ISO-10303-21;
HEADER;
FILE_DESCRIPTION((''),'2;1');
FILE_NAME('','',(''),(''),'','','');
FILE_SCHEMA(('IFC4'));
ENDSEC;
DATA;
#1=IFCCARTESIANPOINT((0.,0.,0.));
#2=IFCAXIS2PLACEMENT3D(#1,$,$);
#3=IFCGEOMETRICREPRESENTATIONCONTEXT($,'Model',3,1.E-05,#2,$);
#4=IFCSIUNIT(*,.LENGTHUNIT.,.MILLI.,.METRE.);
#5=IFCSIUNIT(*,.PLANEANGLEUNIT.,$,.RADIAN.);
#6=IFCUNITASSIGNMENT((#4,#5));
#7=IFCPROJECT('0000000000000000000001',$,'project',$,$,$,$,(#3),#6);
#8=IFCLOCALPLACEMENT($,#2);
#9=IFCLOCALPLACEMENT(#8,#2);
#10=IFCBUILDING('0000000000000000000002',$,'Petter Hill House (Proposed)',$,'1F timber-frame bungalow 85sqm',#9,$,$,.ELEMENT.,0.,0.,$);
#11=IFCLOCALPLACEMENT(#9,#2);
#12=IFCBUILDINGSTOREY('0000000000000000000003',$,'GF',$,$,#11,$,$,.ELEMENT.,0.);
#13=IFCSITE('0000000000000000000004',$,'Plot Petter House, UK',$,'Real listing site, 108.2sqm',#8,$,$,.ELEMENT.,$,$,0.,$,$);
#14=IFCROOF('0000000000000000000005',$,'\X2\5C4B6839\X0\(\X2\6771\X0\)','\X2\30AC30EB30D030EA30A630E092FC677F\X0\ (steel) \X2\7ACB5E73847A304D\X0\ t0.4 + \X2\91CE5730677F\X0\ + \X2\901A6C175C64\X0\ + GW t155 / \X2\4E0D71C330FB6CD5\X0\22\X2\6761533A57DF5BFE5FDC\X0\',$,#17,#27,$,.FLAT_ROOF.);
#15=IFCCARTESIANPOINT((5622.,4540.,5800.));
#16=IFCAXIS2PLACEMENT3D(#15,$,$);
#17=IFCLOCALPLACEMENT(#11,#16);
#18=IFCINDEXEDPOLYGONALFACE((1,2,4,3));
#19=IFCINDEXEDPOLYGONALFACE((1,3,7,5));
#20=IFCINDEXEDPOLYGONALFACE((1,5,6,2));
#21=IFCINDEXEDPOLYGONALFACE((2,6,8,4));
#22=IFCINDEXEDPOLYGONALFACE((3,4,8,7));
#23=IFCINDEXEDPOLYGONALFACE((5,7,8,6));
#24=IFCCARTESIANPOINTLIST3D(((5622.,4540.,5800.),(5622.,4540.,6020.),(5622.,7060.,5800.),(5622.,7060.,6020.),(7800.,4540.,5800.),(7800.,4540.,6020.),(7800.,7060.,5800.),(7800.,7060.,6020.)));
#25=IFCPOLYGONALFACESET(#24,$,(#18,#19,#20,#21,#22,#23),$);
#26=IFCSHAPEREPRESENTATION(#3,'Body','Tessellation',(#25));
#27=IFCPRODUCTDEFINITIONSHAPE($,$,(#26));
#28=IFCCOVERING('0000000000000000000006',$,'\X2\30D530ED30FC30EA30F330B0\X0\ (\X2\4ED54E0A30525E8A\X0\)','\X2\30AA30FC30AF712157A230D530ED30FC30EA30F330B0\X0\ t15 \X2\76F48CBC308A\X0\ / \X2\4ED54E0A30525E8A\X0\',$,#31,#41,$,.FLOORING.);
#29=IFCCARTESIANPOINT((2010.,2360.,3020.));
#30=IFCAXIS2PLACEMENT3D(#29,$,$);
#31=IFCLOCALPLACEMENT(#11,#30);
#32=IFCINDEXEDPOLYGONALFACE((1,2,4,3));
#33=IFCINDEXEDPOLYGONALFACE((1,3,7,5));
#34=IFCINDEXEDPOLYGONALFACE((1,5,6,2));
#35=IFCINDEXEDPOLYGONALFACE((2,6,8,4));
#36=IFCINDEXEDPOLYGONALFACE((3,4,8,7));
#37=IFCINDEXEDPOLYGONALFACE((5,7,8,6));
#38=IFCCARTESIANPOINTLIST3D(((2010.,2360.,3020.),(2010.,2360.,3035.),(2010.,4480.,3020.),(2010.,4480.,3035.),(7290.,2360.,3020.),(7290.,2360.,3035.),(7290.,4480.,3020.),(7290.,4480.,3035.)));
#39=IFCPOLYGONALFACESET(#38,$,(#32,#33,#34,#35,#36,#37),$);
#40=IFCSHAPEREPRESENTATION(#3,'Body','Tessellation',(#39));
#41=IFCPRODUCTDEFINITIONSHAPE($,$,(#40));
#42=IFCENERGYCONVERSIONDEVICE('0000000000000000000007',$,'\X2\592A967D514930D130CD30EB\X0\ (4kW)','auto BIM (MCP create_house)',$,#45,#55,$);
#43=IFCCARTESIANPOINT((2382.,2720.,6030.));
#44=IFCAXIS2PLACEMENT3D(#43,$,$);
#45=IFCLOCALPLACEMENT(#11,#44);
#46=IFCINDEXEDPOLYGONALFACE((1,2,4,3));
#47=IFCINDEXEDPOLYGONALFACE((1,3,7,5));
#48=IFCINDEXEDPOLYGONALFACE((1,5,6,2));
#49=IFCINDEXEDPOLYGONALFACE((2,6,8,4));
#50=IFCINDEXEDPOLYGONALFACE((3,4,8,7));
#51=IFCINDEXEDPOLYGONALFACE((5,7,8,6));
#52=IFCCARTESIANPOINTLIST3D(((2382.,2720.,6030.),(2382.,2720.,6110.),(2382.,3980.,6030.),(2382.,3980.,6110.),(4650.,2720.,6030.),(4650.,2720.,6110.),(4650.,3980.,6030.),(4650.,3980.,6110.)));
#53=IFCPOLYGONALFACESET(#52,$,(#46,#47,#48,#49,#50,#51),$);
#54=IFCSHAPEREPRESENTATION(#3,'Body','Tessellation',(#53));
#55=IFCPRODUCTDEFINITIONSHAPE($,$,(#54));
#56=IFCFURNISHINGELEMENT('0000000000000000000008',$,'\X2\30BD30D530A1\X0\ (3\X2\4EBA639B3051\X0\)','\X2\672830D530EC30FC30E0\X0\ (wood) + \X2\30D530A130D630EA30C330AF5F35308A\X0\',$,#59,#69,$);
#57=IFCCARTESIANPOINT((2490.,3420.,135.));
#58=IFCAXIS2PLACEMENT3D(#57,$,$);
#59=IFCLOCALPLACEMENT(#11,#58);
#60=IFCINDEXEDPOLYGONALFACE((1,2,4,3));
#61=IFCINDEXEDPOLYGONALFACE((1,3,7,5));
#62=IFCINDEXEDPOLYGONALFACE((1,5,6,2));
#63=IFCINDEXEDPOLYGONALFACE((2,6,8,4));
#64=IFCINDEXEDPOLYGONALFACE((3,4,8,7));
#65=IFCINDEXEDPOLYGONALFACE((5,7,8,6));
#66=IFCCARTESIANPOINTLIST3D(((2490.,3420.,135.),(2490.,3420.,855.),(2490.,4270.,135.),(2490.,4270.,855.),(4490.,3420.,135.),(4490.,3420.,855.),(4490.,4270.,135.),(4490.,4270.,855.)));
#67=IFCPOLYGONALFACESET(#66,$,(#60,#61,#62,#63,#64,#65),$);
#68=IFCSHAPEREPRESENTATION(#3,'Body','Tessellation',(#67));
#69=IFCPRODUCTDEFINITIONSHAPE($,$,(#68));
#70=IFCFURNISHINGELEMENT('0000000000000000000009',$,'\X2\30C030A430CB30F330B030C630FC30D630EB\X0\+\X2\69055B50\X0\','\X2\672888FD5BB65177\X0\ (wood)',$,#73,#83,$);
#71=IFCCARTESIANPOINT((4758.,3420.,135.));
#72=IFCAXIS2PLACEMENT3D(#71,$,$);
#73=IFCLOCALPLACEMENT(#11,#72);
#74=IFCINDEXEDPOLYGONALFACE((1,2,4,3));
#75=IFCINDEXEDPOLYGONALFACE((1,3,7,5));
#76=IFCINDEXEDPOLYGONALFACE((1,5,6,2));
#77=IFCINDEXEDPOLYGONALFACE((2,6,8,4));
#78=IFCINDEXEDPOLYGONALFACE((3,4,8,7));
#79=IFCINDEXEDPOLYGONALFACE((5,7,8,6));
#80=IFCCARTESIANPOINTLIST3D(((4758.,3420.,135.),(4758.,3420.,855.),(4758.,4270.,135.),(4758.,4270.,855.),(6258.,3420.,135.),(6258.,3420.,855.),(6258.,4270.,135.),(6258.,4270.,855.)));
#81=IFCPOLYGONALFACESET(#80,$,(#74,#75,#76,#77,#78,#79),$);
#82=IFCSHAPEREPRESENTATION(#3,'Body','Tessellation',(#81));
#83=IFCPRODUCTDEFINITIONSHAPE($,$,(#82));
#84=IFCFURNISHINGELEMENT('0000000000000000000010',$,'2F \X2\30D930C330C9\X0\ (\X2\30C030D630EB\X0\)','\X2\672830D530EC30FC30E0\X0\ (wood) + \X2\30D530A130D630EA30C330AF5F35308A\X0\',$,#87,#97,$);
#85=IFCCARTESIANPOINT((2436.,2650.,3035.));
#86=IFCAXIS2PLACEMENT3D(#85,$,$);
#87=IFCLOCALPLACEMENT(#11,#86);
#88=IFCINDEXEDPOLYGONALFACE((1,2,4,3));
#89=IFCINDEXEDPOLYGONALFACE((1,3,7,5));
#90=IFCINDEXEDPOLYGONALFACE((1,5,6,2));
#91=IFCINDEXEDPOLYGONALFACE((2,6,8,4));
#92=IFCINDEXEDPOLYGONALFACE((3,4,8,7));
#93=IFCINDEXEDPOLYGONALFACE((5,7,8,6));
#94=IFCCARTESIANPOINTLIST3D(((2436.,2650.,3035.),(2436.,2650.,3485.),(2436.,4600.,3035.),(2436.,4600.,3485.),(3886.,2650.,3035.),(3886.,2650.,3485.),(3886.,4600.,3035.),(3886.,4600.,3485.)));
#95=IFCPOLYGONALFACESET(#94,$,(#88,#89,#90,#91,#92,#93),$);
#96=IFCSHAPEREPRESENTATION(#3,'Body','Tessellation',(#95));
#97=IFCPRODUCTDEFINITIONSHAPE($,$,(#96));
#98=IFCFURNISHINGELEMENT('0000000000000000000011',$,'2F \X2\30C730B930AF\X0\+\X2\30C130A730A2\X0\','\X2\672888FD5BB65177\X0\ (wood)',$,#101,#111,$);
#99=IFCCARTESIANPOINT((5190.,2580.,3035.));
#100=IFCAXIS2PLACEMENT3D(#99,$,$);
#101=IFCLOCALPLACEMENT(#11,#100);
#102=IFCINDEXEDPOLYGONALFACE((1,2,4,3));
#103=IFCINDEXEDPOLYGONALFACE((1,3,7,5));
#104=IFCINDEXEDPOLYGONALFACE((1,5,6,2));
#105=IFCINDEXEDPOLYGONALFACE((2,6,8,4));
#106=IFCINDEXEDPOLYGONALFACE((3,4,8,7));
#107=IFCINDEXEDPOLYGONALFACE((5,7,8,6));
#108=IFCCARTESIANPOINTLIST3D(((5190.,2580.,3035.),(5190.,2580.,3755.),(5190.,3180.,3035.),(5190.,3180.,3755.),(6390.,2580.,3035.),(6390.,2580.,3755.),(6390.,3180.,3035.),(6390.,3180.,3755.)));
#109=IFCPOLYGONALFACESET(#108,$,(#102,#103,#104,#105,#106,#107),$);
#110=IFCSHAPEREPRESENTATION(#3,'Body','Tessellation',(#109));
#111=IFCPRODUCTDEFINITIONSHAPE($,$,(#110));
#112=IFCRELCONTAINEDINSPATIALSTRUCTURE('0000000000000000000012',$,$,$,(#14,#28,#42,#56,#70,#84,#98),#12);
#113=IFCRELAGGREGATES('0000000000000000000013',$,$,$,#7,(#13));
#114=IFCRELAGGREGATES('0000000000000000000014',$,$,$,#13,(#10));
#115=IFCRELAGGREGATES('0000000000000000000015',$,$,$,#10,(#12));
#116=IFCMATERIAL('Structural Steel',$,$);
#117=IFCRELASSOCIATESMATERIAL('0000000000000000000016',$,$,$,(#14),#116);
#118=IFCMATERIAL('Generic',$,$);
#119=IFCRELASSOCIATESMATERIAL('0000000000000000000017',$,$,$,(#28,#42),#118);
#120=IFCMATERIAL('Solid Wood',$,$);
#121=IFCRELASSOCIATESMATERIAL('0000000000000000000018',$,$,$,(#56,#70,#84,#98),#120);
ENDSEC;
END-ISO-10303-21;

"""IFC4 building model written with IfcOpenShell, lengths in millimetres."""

from ifc_helpers import new_model, si_unit, frame, frame_2d, origin, place, context, project, spatial, rectangle, extrude, material, element, save


model = new_model("IFC4")

# Units and contexts
model_context = context("Model", 3, precision=1e-05, world=origin())
ifc_project = project(units=[si_unit("LENGTHUNIT", "METRE", prefix="MILLI"), si_unit("PLANEANGLEUNIT", "RADIAN")], contexts=[model_context])

# Site, building, storey
site_placement = place(None, origin())
site = spatial("IfcSite", under=ifc_project, at=site_placement, Name="Plot Petter House, UK", ObjectType="Real listing site, 108.2sqm", CompositionType="ELEMENT", RefElevation=0.0)
building_placement = place(site_placement, origin())
building = spatial("IfcBuilding", under=site, at=building_placement, Name="Petter Hill House (Proposed)", ObjectType="1F timber-frame bungalow 85sqm", CompositionType="ELEMENT", ElevationOfRefHeight=0.0, ElevationOfTerrain=0.0)
storey_placement = place(building_placement, origin())
storey = spatial("IfcBuildingStorey", under=building, at=storey_placement, Name="GF", CompositionType="ELEMENT", Elevation=0.0)

# Shared definitions
ifc_material_1 = material(Name="Solid Wood")

# Roof
ifc_material_2 = material(Name="Structural Steel")
roof_1_placement = place(storey_placement, frame((5622.0, 4540.0, 5800.0)))
element("IfcRoof", 1, at=roof_1_placement, inside=storey, material=ifc_material_2, Name="屋根(東)", Description="ガルバリウム鋼板 (steel) 立平葺き t0.4 + 野地板 + 通気層 + GW t155 / 不燃・法22条区域対応", PredefinedType="FLAT_ROOF", context=model_context, shape_type="SweptSolid", body=[
    extrude(rectangle(XDim=2178.0, YDim=2520.0, at=frame_2d((1089.0, 1260.0))), frame((5622.0, 4540.0, 5800.0)), (0.0, 0.0, 1.0), 220.0),
])

# Covering
ifc_material_3 = material(Name="Generic")
covering_placement = place(storey_placement, frame((2010.0, 2360.0, 3020.0)))
element("IfcCovering", 2, at=covering_placement, inside=storey, material=ifc_material_3, Name="フローリング (仕上げ床)", Description="オーク無垢フローリング t15 直貼り / 仕上げ床", PredefinedType="FLOORING", context=model_context, shape_type="SweptSolid", body=[
    extrude(rectangle(XDim=5280.0, YDim=2120.0, at=frame_2d((2640.0, 1060.0))), frame((2010.0, 2360.0, 3020.0)), (0.0, 0.0, 1.0), 15.0),
])

# Energy conversion device
energy_conversion_device_placement = place(storey_placement, frame((2382.0, 2720.0, 6030.0)))
element("IfcEnergyConversionDevice", 3, at=energy_conversion_device_placement, inside=storey, material=ifc_material_3, Name="太陽光パネル (4kW)", Description="auto BIM (MCP create_house)", context=model_context, shape_type="SweptSolid", body=[
    extrude(rectangle(XDim=2268.0, YDim=1260.0, at=frame_2d((1134.0, 630.0))), frame((2382.0, 2720.0, 6030.0)), (0.0, 0.0, 1.0), 80.0),
])

# Furnishing elements
furnishing_1_placement = place(storey_placement, frame((2490.0, 3420.0, 135.0)))
element("IfcFurnishingElement", 4, at=furnishing_1_placement, inside=storey, material=ifc_material_1, Name="ソファ (3人掛け)", Description="木フレーム (wood) + ファブリック張り", context=model_context, shape_type="SweptSolid", body=[
    extrude(rectangle(XDim=2000.0, YDim=850.0, at=frame_2d((1000.0, 425.0))), frame((2490.0, 3420.0, 135.0)), (0.0, 0.0, 1.0), 720.0),
])
furnishing_2_placement = place(storey_placement, frame((4758.0, 3420.0, 135.0)))
element("IfcFurnishingElement", 5, at=furnishing_2_placement, inside=storey, material=ifc_material_1, Name="ダイニングテーブル+椅子", Description="木製家具 (wood)", context=model_context, shape_type="SweptSolid", body=[
    extrude(rectangle(XDim=1500.0, YDim=850.0, at=frame_2d((750.0, 425.0))), frame((4758.0, 3420.0, 135.0)), (0.0, 0.0, 1.0), 720.0),
])
furnishing_3_placement = place(storey_placement, frame((2436.0, 2650.0, 3035.0)))
element("IfcFurnishingElement", 6, at=furnishing_3_placement, inside=storey, material=ifc_material_1, Name="2F ベッド (ダブル)", Description="木フレーム (wood) + ファブリック張り", context=model_context, shape_type="SweptSolid", body=[
    extrude(rectangle(XDim=1450.0, YDim=1950.0, at=frame_2d((725.0, 975.0))), frame((2436.0, 2650.0, 3035.0)), (0.0, 0.0, 1.0), 450.0),
])
furnishing_4_placement = place(storey_placement, frame((5190.0, 2580.0, 3035.0)))
element("IfcFurnishingElement", 7, at=furnishing_4_placement, inside=storey, material=ifc_material_1, Name="2F デスク+チェア", Description="木製家具 (wood)", context=model_context, shape_type="SweptSolid", body=[
    extrude(rectangle(XDim=1200.0, YDim=600.0, at=frame_2d((600.0, 300.0))), frame((5190.0, 2580.0, 3035.0)), (0.0, 0.0, 1.0), 720.0),
])

save(model, "model.ifc")
